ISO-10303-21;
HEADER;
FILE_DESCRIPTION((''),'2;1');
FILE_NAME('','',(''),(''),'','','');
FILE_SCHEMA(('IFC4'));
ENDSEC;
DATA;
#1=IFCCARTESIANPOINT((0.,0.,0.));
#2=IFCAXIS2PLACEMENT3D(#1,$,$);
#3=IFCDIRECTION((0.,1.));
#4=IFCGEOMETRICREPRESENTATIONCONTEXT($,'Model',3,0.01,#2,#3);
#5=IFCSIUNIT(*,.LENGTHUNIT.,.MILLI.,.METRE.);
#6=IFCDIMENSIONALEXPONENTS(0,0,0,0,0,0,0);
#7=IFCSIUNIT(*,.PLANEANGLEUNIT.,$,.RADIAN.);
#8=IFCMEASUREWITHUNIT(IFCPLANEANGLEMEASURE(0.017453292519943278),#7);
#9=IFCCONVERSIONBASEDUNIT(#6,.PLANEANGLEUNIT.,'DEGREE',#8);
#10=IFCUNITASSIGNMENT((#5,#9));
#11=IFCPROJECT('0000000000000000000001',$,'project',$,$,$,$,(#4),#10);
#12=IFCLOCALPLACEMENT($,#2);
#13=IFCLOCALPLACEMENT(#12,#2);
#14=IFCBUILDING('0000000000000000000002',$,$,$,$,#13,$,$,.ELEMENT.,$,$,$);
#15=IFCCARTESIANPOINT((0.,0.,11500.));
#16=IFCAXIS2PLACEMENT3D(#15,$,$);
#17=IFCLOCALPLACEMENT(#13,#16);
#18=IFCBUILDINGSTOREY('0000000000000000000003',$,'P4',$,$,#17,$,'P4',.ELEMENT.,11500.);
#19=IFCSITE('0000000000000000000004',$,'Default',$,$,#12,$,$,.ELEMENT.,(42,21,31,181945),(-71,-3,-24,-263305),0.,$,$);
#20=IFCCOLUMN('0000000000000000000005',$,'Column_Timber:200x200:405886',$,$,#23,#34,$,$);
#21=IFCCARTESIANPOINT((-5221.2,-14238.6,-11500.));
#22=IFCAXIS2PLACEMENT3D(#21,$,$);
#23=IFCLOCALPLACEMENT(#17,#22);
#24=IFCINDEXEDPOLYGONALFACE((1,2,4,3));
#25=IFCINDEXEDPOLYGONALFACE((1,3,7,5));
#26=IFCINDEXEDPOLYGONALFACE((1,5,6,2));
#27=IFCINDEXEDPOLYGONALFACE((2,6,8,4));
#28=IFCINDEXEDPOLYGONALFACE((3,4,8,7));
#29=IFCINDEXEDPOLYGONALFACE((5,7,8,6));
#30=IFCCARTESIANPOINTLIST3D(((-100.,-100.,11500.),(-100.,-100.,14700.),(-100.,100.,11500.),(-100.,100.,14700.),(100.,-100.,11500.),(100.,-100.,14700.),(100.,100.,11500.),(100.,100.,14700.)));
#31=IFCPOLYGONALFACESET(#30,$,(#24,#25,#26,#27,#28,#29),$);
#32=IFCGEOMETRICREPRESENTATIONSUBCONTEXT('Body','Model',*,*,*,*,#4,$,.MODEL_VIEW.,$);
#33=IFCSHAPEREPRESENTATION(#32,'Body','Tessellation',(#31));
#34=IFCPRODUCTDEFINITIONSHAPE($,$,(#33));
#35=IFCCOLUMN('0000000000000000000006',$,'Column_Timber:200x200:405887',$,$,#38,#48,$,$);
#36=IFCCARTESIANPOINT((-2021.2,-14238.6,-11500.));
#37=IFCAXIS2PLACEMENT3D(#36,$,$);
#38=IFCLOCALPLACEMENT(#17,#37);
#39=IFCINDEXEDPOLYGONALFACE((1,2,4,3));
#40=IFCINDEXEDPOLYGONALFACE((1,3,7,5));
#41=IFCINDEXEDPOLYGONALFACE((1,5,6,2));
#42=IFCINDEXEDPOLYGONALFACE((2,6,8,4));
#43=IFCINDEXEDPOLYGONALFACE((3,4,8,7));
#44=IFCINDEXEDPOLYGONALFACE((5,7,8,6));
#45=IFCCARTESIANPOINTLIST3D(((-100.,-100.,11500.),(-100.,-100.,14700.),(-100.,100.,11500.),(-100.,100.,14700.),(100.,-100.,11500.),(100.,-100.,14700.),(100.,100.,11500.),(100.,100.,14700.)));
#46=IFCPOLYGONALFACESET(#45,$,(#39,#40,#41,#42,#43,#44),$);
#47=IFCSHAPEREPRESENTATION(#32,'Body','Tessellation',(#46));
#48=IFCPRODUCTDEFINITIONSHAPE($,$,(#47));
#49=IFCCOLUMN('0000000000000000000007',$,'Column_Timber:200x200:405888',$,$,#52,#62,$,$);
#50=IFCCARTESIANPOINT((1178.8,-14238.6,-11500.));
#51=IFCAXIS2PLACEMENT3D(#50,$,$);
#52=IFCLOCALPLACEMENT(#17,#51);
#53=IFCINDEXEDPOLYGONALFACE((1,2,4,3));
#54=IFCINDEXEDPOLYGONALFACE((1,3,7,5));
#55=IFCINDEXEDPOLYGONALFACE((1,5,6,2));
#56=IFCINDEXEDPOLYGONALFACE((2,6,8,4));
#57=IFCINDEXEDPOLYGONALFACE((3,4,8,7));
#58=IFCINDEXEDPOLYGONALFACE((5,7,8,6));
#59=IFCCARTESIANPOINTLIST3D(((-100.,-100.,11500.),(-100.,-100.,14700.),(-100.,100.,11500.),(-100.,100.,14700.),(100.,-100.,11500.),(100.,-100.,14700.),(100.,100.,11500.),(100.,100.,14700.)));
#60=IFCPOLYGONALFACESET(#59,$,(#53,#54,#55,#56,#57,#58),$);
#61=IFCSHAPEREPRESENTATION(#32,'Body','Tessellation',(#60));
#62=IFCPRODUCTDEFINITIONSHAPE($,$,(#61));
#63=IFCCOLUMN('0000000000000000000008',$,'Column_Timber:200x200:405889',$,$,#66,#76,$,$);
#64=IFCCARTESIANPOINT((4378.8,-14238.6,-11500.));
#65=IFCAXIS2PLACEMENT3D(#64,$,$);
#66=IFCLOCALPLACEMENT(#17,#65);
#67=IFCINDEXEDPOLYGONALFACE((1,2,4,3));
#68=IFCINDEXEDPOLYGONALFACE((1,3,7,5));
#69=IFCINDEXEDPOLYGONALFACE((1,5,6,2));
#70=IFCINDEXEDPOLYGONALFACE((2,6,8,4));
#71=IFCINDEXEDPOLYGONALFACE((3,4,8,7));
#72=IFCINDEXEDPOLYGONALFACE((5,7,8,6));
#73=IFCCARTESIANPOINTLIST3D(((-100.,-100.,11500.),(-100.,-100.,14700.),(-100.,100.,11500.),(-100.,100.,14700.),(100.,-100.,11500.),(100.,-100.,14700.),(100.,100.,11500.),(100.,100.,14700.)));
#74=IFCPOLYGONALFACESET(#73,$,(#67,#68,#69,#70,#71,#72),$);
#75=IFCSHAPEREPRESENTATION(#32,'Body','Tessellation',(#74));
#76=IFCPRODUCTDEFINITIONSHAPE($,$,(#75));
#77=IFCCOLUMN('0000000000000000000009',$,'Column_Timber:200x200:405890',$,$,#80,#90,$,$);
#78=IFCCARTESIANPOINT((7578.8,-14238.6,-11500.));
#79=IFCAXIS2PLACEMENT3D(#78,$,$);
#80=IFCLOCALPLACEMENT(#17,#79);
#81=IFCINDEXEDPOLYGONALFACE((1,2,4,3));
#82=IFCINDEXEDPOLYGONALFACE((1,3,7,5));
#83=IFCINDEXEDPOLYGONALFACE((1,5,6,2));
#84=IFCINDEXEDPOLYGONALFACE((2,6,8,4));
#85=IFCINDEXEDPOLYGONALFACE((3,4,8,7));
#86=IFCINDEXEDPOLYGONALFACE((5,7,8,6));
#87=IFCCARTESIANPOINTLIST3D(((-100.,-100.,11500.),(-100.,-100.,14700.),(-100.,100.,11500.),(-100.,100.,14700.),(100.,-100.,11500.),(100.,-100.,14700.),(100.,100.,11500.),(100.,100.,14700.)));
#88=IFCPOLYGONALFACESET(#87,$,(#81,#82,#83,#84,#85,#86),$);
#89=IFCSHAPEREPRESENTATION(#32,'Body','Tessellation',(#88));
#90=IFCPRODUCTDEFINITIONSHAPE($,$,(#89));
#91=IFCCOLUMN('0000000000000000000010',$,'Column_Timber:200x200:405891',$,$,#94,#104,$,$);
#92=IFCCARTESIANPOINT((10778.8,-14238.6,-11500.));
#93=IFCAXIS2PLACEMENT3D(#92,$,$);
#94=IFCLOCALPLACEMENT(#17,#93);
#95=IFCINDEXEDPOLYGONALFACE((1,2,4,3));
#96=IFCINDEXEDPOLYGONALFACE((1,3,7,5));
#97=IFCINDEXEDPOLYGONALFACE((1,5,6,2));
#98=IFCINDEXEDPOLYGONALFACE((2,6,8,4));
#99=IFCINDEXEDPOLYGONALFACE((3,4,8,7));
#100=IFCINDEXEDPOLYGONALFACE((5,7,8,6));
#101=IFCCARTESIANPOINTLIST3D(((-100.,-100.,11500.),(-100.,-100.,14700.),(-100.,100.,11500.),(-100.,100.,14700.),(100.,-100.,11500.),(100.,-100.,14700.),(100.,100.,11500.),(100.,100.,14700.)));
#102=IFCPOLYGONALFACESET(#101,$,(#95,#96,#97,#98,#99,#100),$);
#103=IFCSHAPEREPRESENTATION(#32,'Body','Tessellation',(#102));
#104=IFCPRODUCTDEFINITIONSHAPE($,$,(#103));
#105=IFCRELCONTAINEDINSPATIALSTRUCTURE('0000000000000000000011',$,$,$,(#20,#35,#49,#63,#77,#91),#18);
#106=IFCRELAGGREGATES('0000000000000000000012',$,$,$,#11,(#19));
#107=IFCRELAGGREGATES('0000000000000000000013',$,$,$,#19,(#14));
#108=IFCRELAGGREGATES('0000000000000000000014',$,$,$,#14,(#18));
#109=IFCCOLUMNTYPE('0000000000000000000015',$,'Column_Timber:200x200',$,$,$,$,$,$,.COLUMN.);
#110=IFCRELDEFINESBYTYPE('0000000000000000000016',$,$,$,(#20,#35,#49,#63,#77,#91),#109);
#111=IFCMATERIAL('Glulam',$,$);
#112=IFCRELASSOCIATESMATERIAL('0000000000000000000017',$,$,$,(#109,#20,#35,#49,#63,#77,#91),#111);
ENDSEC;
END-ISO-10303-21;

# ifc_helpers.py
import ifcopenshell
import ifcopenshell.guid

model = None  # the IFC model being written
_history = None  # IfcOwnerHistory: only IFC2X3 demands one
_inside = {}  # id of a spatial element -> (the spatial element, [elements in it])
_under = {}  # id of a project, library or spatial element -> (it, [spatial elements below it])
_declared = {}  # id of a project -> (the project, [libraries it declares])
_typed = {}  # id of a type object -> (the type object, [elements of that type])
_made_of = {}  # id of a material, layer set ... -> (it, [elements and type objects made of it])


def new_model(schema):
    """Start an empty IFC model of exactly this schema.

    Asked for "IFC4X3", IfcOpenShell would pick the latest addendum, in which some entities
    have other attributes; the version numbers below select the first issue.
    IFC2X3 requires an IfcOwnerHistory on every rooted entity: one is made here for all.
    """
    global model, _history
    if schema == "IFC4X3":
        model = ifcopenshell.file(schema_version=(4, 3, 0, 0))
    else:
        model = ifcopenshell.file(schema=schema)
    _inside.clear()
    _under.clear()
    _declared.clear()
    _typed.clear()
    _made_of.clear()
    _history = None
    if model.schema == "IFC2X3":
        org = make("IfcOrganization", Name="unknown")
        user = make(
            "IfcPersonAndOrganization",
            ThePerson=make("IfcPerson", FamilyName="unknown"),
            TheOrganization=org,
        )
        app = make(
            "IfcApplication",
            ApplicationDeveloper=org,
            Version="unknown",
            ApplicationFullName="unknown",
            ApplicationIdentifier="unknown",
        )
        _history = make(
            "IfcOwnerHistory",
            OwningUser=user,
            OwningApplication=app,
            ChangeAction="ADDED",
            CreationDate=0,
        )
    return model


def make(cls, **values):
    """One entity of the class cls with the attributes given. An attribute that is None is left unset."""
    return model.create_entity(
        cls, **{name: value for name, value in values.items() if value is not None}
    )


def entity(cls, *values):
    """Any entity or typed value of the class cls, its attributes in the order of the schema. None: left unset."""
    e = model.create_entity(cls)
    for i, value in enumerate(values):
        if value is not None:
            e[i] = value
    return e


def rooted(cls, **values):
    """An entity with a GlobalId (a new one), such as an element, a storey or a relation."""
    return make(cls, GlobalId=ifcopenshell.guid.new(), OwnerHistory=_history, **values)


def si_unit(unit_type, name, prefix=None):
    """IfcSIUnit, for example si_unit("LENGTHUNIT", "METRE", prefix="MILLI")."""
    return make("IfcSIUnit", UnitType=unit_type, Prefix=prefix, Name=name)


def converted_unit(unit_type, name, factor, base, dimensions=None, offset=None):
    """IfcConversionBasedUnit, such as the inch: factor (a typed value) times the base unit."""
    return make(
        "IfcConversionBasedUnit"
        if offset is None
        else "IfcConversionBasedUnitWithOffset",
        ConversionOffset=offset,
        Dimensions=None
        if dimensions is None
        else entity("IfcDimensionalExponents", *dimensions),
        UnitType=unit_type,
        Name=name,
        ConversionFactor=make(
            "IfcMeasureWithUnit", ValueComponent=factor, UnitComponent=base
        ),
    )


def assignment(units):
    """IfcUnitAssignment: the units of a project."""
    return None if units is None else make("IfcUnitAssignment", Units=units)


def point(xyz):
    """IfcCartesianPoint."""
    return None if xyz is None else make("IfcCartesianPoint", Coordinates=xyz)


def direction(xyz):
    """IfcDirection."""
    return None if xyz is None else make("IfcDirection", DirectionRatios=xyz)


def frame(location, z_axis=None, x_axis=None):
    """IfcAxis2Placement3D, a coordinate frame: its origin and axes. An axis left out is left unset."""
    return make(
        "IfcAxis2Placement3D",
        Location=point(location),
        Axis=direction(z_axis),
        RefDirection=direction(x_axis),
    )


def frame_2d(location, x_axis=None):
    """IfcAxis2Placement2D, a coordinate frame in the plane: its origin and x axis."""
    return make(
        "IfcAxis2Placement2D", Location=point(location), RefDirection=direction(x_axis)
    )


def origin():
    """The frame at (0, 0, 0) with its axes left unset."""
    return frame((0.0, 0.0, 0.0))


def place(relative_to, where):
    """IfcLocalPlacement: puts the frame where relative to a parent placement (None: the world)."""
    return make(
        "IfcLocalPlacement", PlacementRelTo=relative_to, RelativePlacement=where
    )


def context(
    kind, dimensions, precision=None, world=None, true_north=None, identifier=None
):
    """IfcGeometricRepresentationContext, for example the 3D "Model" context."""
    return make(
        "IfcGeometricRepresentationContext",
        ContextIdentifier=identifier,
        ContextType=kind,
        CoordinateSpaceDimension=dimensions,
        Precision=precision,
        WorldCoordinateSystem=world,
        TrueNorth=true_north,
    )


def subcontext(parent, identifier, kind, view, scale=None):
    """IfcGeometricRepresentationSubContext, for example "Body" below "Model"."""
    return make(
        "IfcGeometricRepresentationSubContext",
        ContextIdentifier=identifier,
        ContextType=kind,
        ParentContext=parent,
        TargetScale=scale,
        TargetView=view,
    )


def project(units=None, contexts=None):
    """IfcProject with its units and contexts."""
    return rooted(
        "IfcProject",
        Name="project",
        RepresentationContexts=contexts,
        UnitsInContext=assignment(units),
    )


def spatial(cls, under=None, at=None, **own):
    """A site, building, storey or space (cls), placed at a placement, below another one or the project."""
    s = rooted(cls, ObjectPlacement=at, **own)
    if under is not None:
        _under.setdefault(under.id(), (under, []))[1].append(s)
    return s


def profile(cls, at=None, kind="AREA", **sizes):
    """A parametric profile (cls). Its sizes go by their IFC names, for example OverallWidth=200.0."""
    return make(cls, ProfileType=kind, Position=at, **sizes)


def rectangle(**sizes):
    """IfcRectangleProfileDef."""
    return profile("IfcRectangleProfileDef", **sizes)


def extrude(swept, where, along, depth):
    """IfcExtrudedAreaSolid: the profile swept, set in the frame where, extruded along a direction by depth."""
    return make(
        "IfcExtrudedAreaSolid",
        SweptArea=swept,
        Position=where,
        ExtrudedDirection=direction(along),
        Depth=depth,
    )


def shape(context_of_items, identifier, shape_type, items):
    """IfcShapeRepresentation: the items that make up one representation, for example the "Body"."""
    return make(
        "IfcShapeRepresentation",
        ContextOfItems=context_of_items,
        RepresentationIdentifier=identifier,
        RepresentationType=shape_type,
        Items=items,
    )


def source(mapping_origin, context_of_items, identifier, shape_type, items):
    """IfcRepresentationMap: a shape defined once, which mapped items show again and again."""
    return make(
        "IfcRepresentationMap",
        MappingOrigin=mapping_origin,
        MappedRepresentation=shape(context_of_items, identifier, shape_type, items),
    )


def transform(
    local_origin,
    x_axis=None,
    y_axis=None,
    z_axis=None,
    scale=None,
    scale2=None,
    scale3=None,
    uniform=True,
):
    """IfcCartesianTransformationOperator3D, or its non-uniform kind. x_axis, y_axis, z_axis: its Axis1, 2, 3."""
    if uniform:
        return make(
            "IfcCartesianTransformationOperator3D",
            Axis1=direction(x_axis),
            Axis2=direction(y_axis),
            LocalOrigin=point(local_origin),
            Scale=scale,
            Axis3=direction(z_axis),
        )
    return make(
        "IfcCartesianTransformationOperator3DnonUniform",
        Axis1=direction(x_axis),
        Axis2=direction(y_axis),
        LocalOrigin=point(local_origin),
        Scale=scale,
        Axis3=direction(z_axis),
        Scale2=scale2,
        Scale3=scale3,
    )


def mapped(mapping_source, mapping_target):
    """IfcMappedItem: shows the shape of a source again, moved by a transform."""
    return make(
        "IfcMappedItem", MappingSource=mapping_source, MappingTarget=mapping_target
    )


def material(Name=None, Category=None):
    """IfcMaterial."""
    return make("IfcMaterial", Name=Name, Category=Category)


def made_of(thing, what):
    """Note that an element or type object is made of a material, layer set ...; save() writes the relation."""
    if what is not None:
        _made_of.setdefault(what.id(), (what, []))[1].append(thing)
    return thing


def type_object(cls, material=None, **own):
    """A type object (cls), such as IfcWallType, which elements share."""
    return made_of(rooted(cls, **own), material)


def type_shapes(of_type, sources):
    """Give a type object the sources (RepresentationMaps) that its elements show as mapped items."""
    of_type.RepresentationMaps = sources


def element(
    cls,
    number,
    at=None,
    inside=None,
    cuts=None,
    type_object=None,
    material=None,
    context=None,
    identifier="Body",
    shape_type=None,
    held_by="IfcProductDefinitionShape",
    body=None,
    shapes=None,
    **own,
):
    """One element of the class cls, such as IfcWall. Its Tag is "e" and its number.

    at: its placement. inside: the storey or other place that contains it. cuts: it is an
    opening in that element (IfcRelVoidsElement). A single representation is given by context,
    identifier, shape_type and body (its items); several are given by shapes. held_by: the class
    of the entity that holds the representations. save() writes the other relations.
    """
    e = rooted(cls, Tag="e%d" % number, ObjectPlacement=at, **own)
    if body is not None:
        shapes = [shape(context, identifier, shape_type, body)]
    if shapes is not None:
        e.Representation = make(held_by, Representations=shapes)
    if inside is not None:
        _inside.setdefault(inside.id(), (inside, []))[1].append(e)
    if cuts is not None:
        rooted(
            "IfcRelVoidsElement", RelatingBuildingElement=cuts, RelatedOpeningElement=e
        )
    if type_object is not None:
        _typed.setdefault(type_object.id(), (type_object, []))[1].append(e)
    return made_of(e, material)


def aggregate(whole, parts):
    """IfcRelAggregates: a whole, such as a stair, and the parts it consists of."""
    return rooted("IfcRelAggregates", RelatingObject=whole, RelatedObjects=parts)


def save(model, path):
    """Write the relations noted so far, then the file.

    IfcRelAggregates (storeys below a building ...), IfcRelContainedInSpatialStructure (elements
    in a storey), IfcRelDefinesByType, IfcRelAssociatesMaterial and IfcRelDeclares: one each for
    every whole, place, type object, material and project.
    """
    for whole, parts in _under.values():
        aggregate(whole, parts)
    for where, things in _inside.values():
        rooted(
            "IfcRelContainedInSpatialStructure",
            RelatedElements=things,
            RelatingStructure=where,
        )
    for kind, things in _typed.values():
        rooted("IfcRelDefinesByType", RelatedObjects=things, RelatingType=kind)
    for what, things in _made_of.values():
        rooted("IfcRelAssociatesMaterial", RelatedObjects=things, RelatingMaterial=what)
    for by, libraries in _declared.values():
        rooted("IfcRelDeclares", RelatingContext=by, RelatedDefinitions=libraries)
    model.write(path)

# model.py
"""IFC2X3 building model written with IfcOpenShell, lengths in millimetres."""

from ifc_helpers import new_model, entity, si_unit, converted_unit, direction, frame, frame_2d, origin, place, context, subcontext, project, spatial, rectangle, extrude, source, transform, mapped, material, type_object, type_shapes, element, save


model = new_model("IFC2X3")

# Units and contexts
model_context = context("Model", 3, precision=0.01, world=origin(), true_north=direction((0.0, 1.0)))
body_context = subcontext(model_context, "Body", "Model", "MODEL_VIEW")
ifc_project = project(units=[si_unit("LENGTHUNIT", "METRE", prefix="MILLI"), converted_unit("PLANEANGLEUNIT", "DEGREE", entity("IfcPlaneAngleMeasure", 0.017453292519943278), si_unit("PLANEANGLEUNIT", "RADIAN"), dimensions=[0, 0, 0, 0, 0, 0, 0])], contexts=[model_context])

# Site, building, storey
site_placement = place(None, origin())
site = spatial("IfcSite", under=ifc_project, at=site_placement, Name="Default", CompositionType="ELEMENT", RefLatitude=(42, 21, 31, 181945), RefLongitude=(-71, -3, -24, -263305), RefElevation=0.0)
building_placement = place(site_placement, origin())
building = spatial("IfcBuilding", under=site, at=building_placement, CompositionType="ELEMENT")
storey_placement = place(building_placement, frame((0.0, 0.0, 11500.0)))
storey = spatial("IfcBuildingStorey", under=building, at=storey_placement, Name="P4", LongName="P4", CompositionType="ELEMENT", Elevation=11500.0)

# Columns
ifc_material_1 = material(Name="Glulam")
column_type = type_object("IfcColumnType", Name="Column_Timber:200x200", PredefinedType="COLUMN", material=ifc_material_1)
shared_shape = source(origin(), body_context, "Body", "SweptSolid", [
    extrude(rectangle(XDim=200.0, YDim=200.0, at=frame_2d((0.0, 0.0), x_axis=(1.0, 0.0))), frame((0.0, 0.0, 11500.0), z_axis=(0.0, 0.0, 1.0), x_axis=(-1.0, 0.0, 0.0)), (0.0, 0.0, 1.0), 3200.0),
])
type_shapes(column_type, [shared_shape])
for number, where, name in (
    (1, (-5221.2, -14238.6, -11500.0), "Column_Timber:200x200:405886"),
    (2, (-2021.2, -14238.6, -11500.0), "Column_Timber:200x200:405887"),
    (3, (1178.8, -14238.6, -11500.0), "Column_Timber:200x200:405888"),
    (4, (4378.8, -14238.6, -11500.0), "Column_Timber:200x200:405889"),
    (5, (7578.8, -14238.6, -11500.0), "Column_Timber:200x200:405890"),
    (6, (10778.8, -14238.6, -11500.0), "Column_Timber:200x200:405891"),
):
    element("IfcColumn", number, at=place(storey_placement, frame(where)), inside=storey, type_object=column_type, material=ifc_material_1, Name=name, context=body_context, shape_type="MappedRepresentation", body=[
        mapped(shared_shape, transform((0.0, 0.0, 0.0), scale=1.0)),
    ])

save(model, "model.ifc")
